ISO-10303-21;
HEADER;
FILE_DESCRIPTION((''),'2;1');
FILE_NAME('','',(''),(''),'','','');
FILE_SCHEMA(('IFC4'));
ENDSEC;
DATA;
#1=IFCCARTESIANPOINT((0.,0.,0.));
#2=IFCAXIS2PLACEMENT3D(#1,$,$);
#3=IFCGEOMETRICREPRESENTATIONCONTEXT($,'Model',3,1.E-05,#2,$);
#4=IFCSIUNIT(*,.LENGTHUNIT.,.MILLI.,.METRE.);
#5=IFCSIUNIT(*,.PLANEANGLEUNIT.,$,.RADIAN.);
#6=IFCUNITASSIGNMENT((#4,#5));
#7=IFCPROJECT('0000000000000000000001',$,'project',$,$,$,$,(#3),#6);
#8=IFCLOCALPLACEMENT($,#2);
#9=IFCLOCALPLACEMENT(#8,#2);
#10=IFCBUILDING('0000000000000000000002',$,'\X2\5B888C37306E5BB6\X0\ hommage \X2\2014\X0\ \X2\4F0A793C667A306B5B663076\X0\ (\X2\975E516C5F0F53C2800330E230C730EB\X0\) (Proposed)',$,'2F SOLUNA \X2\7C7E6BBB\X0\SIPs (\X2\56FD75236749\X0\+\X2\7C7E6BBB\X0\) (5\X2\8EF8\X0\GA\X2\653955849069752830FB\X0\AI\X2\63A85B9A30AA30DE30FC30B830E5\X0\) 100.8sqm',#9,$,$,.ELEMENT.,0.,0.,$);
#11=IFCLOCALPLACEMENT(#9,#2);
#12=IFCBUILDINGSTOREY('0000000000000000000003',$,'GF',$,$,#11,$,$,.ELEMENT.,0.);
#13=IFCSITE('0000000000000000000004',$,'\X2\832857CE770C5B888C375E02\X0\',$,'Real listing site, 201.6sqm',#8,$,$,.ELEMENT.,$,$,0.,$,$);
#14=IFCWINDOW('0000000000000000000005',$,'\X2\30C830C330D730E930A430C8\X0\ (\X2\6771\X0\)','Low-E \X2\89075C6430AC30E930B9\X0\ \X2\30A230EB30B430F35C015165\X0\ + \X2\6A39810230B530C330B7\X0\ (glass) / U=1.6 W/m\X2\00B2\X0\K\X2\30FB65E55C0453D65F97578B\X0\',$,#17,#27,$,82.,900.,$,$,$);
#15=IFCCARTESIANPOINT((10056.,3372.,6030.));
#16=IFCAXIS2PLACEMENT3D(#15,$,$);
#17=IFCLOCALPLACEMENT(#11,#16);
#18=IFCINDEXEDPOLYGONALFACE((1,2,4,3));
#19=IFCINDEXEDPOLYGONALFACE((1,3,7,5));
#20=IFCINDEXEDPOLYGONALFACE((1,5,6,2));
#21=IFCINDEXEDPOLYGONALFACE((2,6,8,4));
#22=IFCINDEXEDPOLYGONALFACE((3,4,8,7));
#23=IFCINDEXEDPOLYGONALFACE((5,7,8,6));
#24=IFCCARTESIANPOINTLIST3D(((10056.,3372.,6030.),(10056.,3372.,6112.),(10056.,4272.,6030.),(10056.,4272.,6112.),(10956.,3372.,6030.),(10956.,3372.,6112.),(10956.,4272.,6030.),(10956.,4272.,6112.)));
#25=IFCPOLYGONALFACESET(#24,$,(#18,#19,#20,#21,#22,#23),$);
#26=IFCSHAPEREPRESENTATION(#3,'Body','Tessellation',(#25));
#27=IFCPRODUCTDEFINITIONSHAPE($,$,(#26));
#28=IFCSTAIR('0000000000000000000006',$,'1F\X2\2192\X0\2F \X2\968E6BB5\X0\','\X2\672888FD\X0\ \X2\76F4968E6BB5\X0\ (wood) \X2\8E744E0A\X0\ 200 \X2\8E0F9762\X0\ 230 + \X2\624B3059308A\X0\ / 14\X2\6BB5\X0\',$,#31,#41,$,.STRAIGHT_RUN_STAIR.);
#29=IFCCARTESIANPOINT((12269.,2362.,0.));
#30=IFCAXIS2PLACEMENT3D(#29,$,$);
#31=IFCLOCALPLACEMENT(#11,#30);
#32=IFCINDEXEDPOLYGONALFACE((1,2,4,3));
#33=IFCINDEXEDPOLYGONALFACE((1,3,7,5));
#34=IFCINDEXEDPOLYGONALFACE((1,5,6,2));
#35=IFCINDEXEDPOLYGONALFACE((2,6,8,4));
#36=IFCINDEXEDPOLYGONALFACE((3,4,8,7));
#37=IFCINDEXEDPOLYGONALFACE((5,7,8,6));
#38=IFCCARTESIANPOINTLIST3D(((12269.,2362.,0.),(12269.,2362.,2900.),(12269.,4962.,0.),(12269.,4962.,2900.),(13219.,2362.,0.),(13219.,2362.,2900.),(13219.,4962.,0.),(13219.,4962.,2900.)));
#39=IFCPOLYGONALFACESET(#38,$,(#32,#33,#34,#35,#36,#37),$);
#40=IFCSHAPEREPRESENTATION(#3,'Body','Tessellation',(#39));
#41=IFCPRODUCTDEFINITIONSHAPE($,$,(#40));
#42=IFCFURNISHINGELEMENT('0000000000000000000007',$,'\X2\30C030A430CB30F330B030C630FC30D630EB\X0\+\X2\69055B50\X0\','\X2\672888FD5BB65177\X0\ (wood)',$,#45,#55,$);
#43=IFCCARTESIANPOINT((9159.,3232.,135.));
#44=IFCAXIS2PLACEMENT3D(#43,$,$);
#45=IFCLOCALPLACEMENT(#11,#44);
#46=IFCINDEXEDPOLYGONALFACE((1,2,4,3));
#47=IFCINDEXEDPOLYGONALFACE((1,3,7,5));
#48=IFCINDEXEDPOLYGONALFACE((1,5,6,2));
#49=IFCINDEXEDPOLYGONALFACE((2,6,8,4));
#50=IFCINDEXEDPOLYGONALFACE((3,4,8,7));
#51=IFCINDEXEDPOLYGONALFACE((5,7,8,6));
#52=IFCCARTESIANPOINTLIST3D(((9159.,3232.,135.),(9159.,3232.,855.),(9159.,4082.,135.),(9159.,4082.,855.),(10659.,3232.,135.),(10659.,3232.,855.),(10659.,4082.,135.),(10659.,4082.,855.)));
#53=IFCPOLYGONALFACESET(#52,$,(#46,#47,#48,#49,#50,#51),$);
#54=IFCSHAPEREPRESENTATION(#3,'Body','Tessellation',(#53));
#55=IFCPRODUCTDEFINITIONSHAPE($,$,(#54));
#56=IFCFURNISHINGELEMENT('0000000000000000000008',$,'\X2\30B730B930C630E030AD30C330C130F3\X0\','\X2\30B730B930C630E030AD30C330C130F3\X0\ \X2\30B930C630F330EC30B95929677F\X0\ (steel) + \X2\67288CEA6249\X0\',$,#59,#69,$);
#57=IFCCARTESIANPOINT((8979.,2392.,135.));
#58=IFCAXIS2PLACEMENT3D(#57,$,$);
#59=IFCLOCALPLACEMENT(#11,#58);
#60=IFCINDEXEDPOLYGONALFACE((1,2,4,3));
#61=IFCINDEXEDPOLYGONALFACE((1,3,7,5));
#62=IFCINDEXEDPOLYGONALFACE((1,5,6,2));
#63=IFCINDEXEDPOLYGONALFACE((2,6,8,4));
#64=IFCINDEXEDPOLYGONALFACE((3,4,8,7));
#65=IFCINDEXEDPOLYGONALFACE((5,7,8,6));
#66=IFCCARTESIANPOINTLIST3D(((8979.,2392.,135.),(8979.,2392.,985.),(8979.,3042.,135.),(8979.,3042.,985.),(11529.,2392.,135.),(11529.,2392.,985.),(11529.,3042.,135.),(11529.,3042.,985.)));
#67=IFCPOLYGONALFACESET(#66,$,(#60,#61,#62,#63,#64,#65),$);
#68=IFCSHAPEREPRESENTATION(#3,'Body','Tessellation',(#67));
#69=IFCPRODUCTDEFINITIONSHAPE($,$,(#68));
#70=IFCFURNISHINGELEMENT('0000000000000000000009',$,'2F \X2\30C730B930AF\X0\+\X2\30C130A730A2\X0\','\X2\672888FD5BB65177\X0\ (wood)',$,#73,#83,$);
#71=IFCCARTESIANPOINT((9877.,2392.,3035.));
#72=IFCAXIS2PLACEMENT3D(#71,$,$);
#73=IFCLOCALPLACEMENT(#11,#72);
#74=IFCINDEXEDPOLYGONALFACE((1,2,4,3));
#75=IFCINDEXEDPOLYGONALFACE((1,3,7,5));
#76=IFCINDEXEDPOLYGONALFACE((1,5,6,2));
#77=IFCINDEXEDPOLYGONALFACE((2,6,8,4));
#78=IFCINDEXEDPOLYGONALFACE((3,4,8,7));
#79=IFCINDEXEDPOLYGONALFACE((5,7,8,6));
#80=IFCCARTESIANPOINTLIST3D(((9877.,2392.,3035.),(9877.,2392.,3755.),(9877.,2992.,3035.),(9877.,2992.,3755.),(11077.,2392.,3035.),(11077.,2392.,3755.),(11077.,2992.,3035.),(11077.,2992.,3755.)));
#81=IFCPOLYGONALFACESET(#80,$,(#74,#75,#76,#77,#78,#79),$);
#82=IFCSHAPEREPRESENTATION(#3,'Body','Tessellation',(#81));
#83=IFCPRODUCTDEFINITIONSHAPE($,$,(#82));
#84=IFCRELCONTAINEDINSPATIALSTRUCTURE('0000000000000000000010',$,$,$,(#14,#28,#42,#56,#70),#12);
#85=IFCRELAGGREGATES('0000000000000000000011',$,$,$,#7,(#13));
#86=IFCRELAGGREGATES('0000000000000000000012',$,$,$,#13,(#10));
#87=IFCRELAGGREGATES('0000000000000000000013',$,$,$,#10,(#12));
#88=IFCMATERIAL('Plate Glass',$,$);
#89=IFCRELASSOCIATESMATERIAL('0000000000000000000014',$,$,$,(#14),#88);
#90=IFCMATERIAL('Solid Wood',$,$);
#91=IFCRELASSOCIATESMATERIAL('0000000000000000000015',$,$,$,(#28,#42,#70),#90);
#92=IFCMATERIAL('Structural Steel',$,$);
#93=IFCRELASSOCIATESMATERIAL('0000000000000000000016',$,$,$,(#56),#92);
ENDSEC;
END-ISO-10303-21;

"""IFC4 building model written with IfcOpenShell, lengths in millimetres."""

from ifc_helpers import new_model, si_unit, frame, frame_2d, origin, place, context, project, spatial, rectangle, extrude, material, element, save


model = new_model("IFC4")

# Units and contexts
model_context = context("Model", 3, precision=1e-05, world=origin())
ifc_project = project(units=[si_unit("LENGTHUNIT", "METRE", prefix="MILLI"), si_unit("PLANEANGLEUNIT", "RADIAN")], contexts=[model_context])

# Site, building, storey
site_placement = place(None, origin())
site = spatial("IfcSite", under=ifc_project, at=site_placement, Name="茨城県守谷市", ObjectType="Real listing site, 201.6sqm", CompositionType="ELEMENT", RefElevation=0.0)
building_placement = place(site_placement, origin())
building = spatial("IfcBuilding", under=site, at=building_placement, Name="守谷の家 hommage — 伊礼智に学ぶ (非公式参考モデル) (Proposed)", ObjectType="2F SOLUNA 籾殻SIPs (国産杉+籾殻) (5軸GA改善適用・AI推定オマージュ) 100.8sqm", CompositionType="ELEMENT", ElevationOfRefHeight=0.0, ElevationOfTerrain=0.0)
storey_placement = place(building_placement, origin())
storey = spatial("IfcBuildingStorey", under=building, at=storey_placement, Name="GF", CompositionType="ELEMENT", Elevation=0.0)

# Shared definitions
ifc_material_1 = material(Name="Solid Wood")

# Shared definitions
ifc_material_2 = material(Name="Plate Glass")

# Window
window_1_placement = place(storey_placement, frame((10056.0, 3372.0, 6030.0)))
element("IfcWindow", 1, at=window_1_placement, inside=storey, material=ifc_material_2, Name="トップライト (東)", Description="Low-E 複層ガラス アルゴン封入 + 樹脂サッシ (glass) / U=1.6 W/m²K・日射取得型", OverallHeight=82.0, OverallWidth=900.0, context=model_context, shape_type="SweptSolid", body=[
    extrude(rectangle(XDim=900.0, YDim=900.0, at=frame_2d((450.0, 450.0))), frame((10056.0, 3372.0, 6030.0)), (0.0, 0.0, 1.0), 82.0),
])

# Stair
stair_placement = place(storey_placement, frame((12269.0, 2362.0, 0.0)))
element("IfcStair", 2, at=stair_placement, inside=storey, material=ifc_material_1, Name="1F→2F 階段", Description="木製 直階段 (wood) 蹴上 200 踏面 230 + 手すり / 14段", PredefinedType="STRAIGHT_RUN_STAIR", context=model_context, shape_type="SweptSolid", body=[
    extrude(rectangle(XDim=950.0, YDim=2600.0, at=frame_2d((475.0, 1300.0))), frame((12269.0, 2362.0, 0.0)), (0.0, 0.0, 1.0), 2900.0),
])

# Furnishing elements
furnishing_1_placement = place(storey_placement, frame((9159.0, 3232.0, 135.0)))
element("IfcFurnishingElement", 3, at=furnishing_1_placement, inside=storey, material=ifc_material_1, Name="ダイニングテーブル+椅子", Description="木製家具 (wood)", context=model_context, shape_type="SweptSolid", body=[
    extrude(rectangle(XDim=1500.0, YDim=850.0, at=frame_2d((750.0, 425.0))), frame((9159.0, 3232.0, 135.0)), (0.0, 0.0, 1.0), 720.0),
])
ifc_material_3 = material(Name="Structural Steel")
furnishing_2_placement = place(storey_placement, frame((8979.0, 2392.0, 135.0)))
element("IfcFurnishingElement", 4, at=furnishing_2_placement, inside=storey, material=ifc_material_3, Name="システムキッチン", Description="システムキッチン ステンレス天板 (steel) + 木質扉", context=model_context, shape_type="SweptSolid", body=[
    extrude(rectangle(XDim=2550.0, YDim=650.0, at=frame_2d((1275.0, 325.0))), frame((8979.0, 2392.0, 135.0)), (0.0, 0.0, 1.0), 850.0),
])
furnishing_3_placement = place(storey_placement, frame((9877.0, 2392.0, 3035.0)))
element("IfcFurnishingElement", 5, at=furnishing_3_placement, inside=storey, material=ifc_material_1, Name="2F デスク+チェア", Description="木製家具 (wood)", context=model_context, shape_type="SweptSolid", body=[
    extrude(rectangle(XDim=1200.0, YDim=600.0, at=frame_2d((600.0, 300.0))), frame((9877.0, 2392.0, 3035.0)), (0.0, 0.0, 1.0), 720.0),
])

save(model, "model.ifc")
